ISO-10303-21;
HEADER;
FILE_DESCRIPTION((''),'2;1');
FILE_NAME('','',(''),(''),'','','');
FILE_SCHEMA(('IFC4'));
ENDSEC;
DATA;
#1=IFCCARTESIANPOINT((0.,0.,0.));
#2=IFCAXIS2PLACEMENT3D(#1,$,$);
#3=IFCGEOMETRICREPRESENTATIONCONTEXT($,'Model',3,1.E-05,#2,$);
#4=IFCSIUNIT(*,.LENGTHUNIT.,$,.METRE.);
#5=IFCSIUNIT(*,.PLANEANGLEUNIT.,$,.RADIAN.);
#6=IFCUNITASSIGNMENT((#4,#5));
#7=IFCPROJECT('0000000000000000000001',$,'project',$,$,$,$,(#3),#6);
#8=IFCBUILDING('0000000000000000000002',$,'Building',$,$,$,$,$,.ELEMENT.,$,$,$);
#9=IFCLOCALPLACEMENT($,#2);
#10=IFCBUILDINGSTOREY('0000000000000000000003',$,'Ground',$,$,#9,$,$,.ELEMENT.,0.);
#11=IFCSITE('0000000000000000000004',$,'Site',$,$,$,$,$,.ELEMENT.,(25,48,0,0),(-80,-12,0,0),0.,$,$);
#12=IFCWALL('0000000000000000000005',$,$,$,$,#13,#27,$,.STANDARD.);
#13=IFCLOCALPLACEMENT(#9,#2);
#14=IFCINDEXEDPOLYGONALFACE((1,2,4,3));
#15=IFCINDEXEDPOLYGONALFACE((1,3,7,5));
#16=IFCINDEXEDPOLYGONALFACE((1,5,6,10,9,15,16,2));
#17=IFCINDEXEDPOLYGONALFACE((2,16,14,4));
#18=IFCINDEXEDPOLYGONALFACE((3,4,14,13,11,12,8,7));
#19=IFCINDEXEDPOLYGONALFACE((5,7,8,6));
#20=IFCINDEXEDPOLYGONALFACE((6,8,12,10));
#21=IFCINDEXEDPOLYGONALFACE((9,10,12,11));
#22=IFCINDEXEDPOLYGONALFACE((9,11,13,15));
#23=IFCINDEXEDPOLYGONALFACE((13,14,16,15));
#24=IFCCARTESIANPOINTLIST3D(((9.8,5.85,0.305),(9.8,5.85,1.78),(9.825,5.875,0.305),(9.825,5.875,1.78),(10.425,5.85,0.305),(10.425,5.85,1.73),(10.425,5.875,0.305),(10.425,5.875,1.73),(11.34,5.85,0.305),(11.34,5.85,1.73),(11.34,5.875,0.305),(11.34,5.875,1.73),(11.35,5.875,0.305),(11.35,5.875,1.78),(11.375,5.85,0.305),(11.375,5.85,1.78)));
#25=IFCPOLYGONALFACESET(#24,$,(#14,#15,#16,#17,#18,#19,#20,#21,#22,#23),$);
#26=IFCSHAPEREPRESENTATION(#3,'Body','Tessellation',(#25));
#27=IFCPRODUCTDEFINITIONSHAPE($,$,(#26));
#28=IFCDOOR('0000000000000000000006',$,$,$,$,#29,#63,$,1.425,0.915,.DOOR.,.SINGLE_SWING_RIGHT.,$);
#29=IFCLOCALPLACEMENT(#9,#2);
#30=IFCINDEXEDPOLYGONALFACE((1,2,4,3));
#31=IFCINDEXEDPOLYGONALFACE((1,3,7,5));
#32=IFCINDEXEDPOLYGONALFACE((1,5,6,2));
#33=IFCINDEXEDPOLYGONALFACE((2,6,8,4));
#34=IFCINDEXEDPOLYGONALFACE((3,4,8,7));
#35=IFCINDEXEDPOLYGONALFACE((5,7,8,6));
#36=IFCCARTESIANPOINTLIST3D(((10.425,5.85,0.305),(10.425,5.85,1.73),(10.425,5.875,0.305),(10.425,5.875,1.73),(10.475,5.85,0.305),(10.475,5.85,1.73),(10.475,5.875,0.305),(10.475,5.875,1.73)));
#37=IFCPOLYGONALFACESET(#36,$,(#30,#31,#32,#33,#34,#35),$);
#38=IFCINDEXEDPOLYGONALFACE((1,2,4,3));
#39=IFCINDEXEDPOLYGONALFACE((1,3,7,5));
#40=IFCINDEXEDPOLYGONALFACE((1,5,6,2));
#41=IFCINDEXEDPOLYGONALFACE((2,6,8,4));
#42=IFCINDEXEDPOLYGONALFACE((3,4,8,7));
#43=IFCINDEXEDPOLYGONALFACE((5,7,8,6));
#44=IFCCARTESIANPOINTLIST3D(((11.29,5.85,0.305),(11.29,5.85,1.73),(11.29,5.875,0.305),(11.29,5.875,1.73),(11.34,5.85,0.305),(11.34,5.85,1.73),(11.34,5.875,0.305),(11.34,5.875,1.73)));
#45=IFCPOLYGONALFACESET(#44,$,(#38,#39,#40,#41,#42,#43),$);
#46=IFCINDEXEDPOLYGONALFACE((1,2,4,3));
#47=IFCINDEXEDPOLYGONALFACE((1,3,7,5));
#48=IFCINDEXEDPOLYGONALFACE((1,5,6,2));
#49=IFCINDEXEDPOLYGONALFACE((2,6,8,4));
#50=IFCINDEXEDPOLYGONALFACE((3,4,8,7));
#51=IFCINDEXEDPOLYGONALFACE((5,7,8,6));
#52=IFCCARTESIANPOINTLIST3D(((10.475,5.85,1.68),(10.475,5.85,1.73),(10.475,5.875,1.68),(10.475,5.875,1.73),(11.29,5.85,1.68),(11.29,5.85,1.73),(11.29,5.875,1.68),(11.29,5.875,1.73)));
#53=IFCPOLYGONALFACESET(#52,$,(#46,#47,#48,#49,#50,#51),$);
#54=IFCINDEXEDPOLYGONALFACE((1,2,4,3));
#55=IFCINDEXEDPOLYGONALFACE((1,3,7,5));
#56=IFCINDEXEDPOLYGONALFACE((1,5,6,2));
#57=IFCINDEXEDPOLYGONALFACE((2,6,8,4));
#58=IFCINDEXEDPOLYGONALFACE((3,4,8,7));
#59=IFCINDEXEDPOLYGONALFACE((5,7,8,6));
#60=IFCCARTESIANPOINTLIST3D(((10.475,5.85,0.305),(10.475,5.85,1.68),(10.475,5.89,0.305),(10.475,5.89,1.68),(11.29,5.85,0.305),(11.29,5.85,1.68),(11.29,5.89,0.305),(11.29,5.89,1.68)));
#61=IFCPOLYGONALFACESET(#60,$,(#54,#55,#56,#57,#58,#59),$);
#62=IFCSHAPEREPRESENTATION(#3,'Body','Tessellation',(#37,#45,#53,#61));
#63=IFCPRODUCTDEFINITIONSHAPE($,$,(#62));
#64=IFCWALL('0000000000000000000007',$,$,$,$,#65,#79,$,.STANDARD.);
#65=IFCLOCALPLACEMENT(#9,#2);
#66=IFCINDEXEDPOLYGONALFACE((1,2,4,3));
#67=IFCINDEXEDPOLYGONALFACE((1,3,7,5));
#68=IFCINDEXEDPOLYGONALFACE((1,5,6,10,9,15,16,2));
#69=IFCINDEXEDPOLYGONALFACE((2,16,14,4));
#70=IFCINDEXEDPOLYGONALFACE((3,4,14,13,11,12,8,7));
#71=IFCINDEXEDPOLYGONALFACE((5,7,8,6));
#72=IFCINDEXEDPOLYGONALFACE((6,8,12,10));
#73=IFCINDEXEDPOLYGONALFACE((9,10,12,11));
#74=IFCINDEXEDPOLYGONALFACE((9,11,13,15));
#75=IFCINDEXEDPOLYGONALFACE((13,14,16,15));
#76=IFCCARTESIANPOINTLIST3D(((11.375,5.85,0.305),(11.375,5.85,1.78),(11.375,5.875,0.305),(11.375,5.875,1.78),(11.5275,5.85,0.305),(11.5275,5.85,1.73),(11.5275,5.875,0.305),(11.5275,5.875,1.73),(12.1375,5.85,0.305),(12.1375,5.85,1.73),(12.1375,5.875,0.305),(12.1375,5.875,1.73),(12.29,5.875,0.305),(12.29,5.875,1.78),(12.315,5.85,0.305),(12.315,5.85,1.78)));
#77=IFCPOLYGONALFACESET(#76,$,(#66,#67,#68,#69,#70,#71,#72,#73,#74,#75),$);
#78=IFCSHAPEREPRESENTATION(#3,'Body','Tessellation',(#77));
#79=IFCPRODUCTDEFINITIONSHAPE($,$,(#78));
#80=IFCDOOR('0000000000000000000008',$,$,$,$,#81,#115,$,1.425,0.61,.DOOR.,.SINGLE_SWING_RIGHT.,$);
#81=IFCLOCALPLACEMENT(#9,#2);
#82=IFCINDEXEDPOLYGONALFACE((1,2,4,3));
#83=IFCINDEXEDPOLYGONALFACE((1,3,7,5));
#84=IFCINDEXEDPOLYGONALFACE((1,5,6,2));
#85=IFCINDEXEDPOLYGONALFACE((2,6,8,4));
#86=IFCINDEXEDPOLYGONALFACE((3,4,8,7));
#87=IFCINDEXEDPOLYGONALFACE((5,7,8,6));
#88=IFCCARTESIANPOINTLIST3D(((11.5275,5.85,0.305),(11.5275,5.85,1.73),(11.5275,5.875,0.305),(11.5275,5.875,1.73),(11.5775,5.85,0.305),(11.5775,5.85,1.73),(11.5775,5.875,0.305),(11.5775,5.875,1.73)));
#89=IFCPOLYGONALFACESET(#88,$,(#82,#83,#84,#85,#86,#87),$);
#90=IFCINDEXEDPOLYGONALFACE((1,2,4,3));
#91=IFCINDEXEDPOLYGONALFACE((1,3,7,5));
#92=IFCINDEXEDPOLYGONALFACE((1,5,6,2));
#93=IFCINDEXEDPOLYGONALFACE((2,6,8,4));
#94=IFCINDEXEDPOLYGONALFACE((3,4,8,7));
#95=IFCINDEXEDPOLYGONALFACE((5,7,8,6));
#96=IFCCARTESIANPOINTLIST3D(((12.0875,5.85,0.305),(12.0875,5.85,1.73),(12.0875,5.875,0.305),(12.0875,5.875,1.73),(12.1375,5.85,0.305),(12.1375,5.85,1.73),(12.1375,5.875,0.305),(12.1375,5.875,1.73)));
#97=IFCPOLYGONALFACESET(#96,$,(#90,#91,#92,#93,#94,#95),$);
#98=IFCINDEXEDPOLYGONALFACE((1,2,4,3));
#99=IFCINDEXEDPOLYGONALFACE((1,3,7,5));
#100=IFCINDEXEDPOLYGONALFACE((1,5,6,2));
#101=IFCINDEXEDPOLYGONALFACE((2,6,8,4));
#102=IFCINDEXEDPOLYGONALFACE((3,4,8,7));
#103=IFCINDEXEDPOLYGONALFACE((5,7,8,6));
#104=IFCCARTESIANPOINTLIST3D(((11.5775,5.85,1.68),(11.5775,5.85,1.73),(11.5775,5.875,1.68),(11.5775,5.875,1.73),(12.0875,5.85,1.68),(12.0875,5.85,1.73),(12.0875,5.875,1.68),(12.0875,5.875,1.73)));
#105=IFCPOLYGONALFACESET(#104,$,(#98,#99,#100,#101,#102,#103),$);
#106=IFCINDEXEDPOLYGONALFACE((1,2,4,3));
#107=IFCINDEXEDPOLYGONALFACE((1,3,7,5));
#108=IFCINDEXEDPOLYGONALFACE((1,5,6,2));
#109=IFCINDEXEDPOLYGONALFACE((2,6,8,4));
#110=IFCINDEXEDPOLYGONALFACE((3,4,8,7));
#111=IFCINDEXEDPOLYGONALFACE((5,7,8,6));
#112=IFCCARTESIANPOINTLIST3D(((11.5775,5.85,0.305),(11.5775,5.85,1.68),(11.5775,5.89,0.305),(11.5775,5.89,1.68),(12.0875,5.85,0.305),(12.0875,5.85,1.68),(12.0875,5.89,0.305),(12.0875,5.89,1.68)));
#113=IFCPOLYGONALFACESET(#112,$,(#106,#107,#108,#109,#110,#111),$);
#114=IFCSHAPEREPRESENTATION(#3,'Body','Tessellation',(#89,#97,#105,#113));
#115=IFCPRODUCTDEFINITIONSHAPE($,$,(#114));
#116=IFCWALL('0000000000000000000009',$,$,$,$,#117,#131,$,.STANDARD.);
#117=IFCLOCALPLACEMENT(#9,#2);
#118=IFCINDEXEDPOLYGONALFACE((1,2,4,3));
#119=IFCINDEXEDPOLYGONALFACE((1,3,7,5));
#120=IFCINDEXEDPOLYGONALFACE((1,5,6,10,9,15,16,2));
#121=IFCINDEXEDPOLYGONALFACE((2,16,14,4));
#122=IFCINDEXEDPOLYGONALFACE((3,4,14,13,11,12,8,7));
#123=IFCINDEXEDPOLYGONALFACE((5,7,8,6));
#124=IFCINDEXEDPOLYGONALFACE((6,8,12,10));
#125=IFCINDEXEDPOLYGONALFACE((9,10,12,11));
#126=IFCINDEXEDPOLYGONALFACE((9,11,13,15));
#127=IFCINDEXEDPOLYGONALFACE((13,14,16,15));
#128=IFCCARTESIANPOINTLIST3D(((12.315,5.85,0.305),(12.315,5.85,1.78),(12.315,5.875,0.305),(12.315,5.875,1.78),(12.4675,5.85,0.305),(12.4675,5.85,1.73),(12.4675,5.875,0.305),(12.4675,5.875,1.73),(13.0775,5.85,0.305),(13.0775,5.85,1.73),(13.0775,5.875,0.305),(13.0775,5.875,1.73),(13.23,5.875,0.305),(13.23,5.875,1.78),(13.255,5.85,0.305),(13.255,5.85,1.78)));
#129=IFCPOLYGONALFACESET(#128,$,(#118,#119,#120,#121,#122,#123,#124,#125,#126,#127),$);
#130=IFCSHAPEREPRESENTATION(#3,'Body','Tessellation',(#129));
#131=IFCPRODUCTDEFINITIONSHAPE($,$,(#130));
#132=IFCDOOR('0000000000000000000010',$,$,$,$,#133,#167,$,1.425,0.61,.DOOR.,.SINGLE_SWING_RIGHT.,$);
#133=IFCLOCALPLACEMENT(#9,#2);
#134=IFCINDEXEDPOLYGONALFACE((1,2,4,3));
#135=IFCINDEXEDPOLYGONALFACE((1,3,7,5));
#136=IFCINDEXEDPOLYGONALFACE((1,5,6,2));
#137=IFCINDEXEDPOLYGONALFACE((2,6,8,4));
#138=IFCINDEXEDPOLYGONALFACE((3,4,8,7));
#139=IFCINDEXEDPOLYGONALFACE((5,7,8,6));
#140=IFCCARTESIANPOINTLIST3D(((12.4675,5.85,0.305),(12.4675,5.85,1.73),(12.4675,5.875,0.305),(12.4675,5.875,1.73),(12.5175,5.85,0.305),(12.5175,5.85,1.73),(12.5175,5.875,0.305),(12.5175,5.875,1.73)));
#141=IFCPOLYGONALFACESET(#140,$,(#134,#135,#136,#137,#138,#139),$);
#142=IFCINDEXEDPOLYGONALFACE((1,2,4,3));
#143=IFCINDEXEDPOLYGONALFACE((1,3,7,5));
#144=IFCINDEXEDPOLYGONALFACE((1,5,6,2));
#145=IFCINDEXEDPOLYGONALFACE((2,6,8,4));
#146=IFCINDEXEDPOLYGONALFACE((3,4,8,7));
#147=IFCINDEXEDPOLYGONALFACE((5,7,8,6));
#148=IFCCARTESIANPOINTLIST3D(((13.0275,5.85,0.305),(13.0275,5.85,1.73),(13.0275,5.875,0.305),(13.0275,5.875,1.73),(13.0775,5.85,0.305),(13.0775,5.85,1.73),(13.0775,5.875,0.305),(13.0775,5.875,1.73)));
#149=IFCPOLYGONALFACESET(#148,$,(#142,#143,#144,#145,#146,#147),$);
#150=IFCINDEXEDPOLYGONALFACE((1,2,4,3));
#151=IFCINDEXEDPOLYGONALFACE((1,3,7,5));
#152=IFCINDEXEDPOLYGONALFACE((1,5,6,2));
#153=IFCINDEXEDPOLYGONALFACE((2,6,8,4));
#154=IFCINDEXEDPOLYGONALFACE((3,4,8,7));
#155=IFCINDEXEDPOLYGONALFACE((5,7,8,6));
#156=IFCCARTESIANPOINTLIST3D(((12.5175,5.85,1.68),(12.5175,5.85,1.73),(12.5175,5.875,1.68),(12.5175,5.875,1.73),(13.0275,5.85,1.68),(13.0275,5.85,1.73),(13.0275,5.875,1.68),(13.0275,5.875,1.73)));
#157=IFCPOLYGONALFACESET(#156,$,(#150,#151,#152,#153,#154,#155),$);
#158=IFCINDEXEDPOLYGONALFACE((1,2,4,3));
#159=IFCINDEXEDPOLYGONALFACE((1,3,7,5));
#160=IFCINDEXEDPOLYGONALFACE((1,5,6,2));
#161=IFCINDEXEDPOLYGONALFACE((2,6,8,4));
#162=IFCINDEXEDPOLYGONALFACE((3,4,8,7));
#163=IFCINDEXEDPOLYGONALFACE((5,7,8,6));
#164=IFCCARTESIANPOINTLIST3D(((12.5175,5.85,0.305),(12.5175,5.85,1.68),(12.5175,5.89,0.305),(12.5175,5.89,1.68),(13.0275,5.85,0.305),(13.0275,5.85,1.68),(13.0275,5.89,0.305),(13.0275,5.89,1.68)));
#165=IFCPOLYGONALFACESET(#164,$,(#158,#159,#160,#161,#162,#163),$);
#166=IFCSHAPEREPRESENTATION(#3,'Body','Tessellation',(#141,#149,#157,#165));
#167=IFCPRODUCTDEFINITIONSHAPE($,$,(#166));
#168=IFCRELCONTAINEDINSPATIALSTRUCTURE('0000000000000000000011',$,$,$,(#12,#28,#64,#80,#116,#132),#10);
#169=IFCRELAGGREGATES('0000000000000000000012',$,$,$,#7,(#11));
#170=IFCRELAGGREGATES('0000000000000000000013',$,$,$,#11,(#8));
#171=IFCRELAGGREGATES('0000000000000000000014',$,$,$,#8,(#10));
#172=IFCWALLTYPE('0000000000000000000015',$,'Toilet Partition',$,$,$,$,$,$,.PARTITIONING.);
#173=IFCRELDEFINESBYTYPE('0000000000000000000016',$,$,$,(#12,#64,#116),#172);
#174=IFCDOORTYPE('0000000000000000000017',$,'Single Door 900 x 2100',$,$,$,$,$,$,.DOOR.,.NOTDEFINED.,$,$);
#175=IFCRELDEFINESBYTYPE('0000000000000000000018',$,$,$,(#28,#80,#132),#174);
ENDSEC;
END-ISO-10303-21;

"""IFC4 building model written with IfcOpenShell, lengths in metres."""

from ifc_helpers import new_model, si_unit, frame, frame_2d, origin, origin_with_axes, origin_2d, place, context, project, spatial, polyline, rectangle, outline, extrude, type_object, element, fill, save


model = new_model("IFC4")

# Units and contexts
model_context = context("Model", 3, precision=1e-05, world=origin())
ifc_project = project(units=[si_unit("LENGTHUNIT", "METRE"), si_unit("PLANEANGLEUNIT", "RADIAN")], contexts=[model_context])

# Site, building, storey
site = spatial("IfcSite", under=ifc_project, Name="Site", CompositionType="ELEMENT", RefLatitude=(25, 48, 0, 0), RefLongitude=(-80, -12, 0, 0), RefElevation=0.0)
building = spatial("IfcBuilding", under=site, Name="Building", CompositionType="ELEMENT")
storey_placement = place(None, origin())
storey = spatial("IfcBuildingStorey", under=building, at=storey_placement, Name="Ground", CompositionType="ELEMENT", Elevation=0.0)

# Shared definitions
door_type = type_object("IfcDoorType", Name="Single Door 900 x 2100", OperationType="NOTDEFINED", PredefinedType="DOOR")

# Walls, openings, doors
wall_type_1 = type_object("IfcWallType", Name="Toilet Partition", PredefinedType="PARTITIONING")
wall_1_placement = place(None, frame((9.825, 5.8625, 0.305), z_axis=(0.0, 0.0, 1.0), x_axis=(1.0, 0.0, 0.0)))
wall_1 = element("IfcWall", 1, at=wall_1_placement, inside=storey, type_object=wall_type_1, PredefinedType="STANDARD", context=model_context, shape_type="SweptSolid", body=[
    extrude(outline(polyline([(-0.025, -0.0125), (1.55, -0.0125), (1.525, 0.0125), (0.0, 0.0125), (-0.025, -0.0125)])), origin(), (0.0, 0.0, 1.0), 1.475),
])
opening_1_placement = place(wall_1_placement, frame((1.0575, 0.0, 0.0), z_axis=(0.0, 0.0, 1.0), x_axis=(1.0, 0.0, 0.0)))
opening_1 = element("IfcOpeningElement", 2, at=opening_1_placement, cuts=wall_1, PredefinedType="OPENING", context=model_context, shape_type="SweptSolid", body=[
    extrude(rectangle(XDim=0.915, YDim=0.027, at=origin_2d()), origin(), (0.0, 0.0, 1.0), 1.425),
])
door_1_placement = place(opening_1_placement, origin_with_axes())
door_1 = element("IfcDoor", 3, at=door_1_placement, inside=storey, type_object=door_type, OperationType="SINGLE_SWING_RIGHT", OverallHeight=1.425, OverallWidth=0.915, PredefinedType="DOOR", context=model_context, shape_type="SweptSolid", body=[
    extrude(rectangle(XDim=0.05, YDim=0.025, at=frame_2d((-0.4325, 0.0))), origin(), (0.0, 0.0, 1.0), 1.425),
    extrude(rectangle(XDim=0.05, YDim=0.025, at=frame_2d((0.4325, 0.0))), origin(), (0.0, 0.0, 1.0), 1.425),
    extrude(rectangle(XDim=0.815, YDim=0.025, at=origin_2d()), frame((0.0, 0.0, 1.375)), (0.0, 0.0, 1.0), 0.05),
    extrude(rectangle(XDim=0.815, YDim=0.04, at=frame_2d((0.0, 0.0075))), origin(), (0.0, 0.0, 1.0), 1.375),
])
fill(opening_1, door_1)
wall_2_placement = place(None, frame((11.375, 5.8625, 0.305), z_axis=(0.0, 0.0, 1.0), x_axis=(1.0, 0.0, 0.0)))
wall_2 = element("IfcWall", 4, at=wall_2_placement, inside=storey, type_object=wall_type_1, PredefinedType="STANDARD", context=model_context, shape_type="SweptSolid", body=[
    extrude(outline(polyline([(0.0, -0.0125), (0.94, -0.0125), (0.915, 0.0125), (0.0, 0.0125), (0.0, -0.0125)])), origin(), (0.0, 0.0, 1.0), 1.475),
])
opening_2_placement = place(wall_2_placement, frame((0.4575, 0.0, 0.0), z_axis=(0.0, 0.0, 1.0), x_axis=(1.0, 0.0, 0.0)))
opening_2 = element("IfcOpeningElement", 5, at=opening_2_placement, cuts=wall_2, PredefinedType="OPENING", context=model_context, shape_type="SweptSolid", body=[
    extrude(rectangle(XDim=0.61, YDim=0.027, at=origin_2d()), origin(), (0.0, 0.0, 1.0), 1.425),
])
door_2_placement = place(opening_2_placement, origin_with_axes())
door_2 = element("IfcDoor", 6, at=door_2_placement, inside=storey, type_object=door_type, OperationType="SINGLE_SWING_RIGHT", OverallHeight=1.425, OverallWidth=0.61, PredefinedType="DOOR", context=model_context, shape_type="SweptSolid", body=[
    extrude(rectangle(XDim=0.05, YDim=0.025, at=frame_2d((-0.28, 0.0))), origin(), (0.0, 0.0, 1.0), 1.425),
    extrude(rectangle(XDim=0.05, YDim=0.025, at=frame_2d((0.28, 0.0))), origin(), (0.0, 0.0, 1.0), 1.425),
    extrude(rectangle(XDim=0.51, YDim=0.025, at=origin_2d()), frame((0.0, 0.0, 1.375)), (0.0, 0.0, 1.0), 0.05),
    extrude(rectangle(XDim=0.51, YDim=0.04, at=frame_2d((0.0, 0.0075))), origin(), (0.0, 0.0, 1.0), 1.375),
])
fill(opening_2, door_2)
wall_3_placement = place(None, frame((12.315, 5.8625, 0.305), z_axis=(0.0, 0.0, 1.0), x_axis=(1.0, 0.0, 0.0)))
wall_3 = element("IfcWall", 7, at=wall_3_placement, inside=storey, type_object=wall_type_1, PredefinedType="STANDARD", context=model_context, shape_type="SweptSolid", body=[
    extrude(outline(polyline([(0.0, -0.0125), (0.94, -0.0125), (0.915, 0.0125), (0.0, 0.0125), (0.0, -0.0125)])), origin(), (0.0, 0.0, 1.0), 1.475),
])
opening_3_placement = place(wall_3_placement, frame((0.4575, 0.0, 0.0), z_axis=(0.0, 0.0, 1.0), x_axis=(1.0, 0.0, 0.0)))
opening_3 = element("IfcOpeningElement", 8, at=opening_3_placement, cuts=wall_3, PredefinedType="OPENING", context=model_context, shape_type="SweptSolid", body=[
    extrude(rectangle(XDim=0.61, YDim=0.027, at=origin_2d()), origin(), (0.0, 0.0, 1.0), 1.425),
])
door_3_placement = place(opening_3_placement, origin_with_axes())
door_3 = element("IfcDoor", 9, at=door_3_placement, inside=storey, type_object=door_type, OperationType="SINGLE_SWING_RIGHT", OverallHeight=1.425, OverallWidth=0.61, PredefinedType="DOOR", context=model_context, shape_type="SweptSolid", body=[
    extrude(rectangle(XDim=0.05, YDim=0.025, at=frame_2d((-0.28, 0.0))), origin(), (0.0, 0.0, 1.0), 1.425),
    extrude(rectangle(XDim=0.05, YDim=0.025, at=frame_2d((0.28, 0.0))), origin(), (0.0, 0.0, 1.0), 1.425),
    extrude(rectangle(XDim=0.51, YDim=0.025, at=origin_2d()), frame((0.0, 0.0, 1.375)), (0.0, 0.0, 1.0), 0.05),
    extrude(rectangle(XDim=0.51, YDim=0.04, at=frame_2d((0.0, 0.0075))), origin(), (0.0, 0.0, 1.0), 1.375),
])
fill(opening_3, door_3)

save(model, "model.ifc")
